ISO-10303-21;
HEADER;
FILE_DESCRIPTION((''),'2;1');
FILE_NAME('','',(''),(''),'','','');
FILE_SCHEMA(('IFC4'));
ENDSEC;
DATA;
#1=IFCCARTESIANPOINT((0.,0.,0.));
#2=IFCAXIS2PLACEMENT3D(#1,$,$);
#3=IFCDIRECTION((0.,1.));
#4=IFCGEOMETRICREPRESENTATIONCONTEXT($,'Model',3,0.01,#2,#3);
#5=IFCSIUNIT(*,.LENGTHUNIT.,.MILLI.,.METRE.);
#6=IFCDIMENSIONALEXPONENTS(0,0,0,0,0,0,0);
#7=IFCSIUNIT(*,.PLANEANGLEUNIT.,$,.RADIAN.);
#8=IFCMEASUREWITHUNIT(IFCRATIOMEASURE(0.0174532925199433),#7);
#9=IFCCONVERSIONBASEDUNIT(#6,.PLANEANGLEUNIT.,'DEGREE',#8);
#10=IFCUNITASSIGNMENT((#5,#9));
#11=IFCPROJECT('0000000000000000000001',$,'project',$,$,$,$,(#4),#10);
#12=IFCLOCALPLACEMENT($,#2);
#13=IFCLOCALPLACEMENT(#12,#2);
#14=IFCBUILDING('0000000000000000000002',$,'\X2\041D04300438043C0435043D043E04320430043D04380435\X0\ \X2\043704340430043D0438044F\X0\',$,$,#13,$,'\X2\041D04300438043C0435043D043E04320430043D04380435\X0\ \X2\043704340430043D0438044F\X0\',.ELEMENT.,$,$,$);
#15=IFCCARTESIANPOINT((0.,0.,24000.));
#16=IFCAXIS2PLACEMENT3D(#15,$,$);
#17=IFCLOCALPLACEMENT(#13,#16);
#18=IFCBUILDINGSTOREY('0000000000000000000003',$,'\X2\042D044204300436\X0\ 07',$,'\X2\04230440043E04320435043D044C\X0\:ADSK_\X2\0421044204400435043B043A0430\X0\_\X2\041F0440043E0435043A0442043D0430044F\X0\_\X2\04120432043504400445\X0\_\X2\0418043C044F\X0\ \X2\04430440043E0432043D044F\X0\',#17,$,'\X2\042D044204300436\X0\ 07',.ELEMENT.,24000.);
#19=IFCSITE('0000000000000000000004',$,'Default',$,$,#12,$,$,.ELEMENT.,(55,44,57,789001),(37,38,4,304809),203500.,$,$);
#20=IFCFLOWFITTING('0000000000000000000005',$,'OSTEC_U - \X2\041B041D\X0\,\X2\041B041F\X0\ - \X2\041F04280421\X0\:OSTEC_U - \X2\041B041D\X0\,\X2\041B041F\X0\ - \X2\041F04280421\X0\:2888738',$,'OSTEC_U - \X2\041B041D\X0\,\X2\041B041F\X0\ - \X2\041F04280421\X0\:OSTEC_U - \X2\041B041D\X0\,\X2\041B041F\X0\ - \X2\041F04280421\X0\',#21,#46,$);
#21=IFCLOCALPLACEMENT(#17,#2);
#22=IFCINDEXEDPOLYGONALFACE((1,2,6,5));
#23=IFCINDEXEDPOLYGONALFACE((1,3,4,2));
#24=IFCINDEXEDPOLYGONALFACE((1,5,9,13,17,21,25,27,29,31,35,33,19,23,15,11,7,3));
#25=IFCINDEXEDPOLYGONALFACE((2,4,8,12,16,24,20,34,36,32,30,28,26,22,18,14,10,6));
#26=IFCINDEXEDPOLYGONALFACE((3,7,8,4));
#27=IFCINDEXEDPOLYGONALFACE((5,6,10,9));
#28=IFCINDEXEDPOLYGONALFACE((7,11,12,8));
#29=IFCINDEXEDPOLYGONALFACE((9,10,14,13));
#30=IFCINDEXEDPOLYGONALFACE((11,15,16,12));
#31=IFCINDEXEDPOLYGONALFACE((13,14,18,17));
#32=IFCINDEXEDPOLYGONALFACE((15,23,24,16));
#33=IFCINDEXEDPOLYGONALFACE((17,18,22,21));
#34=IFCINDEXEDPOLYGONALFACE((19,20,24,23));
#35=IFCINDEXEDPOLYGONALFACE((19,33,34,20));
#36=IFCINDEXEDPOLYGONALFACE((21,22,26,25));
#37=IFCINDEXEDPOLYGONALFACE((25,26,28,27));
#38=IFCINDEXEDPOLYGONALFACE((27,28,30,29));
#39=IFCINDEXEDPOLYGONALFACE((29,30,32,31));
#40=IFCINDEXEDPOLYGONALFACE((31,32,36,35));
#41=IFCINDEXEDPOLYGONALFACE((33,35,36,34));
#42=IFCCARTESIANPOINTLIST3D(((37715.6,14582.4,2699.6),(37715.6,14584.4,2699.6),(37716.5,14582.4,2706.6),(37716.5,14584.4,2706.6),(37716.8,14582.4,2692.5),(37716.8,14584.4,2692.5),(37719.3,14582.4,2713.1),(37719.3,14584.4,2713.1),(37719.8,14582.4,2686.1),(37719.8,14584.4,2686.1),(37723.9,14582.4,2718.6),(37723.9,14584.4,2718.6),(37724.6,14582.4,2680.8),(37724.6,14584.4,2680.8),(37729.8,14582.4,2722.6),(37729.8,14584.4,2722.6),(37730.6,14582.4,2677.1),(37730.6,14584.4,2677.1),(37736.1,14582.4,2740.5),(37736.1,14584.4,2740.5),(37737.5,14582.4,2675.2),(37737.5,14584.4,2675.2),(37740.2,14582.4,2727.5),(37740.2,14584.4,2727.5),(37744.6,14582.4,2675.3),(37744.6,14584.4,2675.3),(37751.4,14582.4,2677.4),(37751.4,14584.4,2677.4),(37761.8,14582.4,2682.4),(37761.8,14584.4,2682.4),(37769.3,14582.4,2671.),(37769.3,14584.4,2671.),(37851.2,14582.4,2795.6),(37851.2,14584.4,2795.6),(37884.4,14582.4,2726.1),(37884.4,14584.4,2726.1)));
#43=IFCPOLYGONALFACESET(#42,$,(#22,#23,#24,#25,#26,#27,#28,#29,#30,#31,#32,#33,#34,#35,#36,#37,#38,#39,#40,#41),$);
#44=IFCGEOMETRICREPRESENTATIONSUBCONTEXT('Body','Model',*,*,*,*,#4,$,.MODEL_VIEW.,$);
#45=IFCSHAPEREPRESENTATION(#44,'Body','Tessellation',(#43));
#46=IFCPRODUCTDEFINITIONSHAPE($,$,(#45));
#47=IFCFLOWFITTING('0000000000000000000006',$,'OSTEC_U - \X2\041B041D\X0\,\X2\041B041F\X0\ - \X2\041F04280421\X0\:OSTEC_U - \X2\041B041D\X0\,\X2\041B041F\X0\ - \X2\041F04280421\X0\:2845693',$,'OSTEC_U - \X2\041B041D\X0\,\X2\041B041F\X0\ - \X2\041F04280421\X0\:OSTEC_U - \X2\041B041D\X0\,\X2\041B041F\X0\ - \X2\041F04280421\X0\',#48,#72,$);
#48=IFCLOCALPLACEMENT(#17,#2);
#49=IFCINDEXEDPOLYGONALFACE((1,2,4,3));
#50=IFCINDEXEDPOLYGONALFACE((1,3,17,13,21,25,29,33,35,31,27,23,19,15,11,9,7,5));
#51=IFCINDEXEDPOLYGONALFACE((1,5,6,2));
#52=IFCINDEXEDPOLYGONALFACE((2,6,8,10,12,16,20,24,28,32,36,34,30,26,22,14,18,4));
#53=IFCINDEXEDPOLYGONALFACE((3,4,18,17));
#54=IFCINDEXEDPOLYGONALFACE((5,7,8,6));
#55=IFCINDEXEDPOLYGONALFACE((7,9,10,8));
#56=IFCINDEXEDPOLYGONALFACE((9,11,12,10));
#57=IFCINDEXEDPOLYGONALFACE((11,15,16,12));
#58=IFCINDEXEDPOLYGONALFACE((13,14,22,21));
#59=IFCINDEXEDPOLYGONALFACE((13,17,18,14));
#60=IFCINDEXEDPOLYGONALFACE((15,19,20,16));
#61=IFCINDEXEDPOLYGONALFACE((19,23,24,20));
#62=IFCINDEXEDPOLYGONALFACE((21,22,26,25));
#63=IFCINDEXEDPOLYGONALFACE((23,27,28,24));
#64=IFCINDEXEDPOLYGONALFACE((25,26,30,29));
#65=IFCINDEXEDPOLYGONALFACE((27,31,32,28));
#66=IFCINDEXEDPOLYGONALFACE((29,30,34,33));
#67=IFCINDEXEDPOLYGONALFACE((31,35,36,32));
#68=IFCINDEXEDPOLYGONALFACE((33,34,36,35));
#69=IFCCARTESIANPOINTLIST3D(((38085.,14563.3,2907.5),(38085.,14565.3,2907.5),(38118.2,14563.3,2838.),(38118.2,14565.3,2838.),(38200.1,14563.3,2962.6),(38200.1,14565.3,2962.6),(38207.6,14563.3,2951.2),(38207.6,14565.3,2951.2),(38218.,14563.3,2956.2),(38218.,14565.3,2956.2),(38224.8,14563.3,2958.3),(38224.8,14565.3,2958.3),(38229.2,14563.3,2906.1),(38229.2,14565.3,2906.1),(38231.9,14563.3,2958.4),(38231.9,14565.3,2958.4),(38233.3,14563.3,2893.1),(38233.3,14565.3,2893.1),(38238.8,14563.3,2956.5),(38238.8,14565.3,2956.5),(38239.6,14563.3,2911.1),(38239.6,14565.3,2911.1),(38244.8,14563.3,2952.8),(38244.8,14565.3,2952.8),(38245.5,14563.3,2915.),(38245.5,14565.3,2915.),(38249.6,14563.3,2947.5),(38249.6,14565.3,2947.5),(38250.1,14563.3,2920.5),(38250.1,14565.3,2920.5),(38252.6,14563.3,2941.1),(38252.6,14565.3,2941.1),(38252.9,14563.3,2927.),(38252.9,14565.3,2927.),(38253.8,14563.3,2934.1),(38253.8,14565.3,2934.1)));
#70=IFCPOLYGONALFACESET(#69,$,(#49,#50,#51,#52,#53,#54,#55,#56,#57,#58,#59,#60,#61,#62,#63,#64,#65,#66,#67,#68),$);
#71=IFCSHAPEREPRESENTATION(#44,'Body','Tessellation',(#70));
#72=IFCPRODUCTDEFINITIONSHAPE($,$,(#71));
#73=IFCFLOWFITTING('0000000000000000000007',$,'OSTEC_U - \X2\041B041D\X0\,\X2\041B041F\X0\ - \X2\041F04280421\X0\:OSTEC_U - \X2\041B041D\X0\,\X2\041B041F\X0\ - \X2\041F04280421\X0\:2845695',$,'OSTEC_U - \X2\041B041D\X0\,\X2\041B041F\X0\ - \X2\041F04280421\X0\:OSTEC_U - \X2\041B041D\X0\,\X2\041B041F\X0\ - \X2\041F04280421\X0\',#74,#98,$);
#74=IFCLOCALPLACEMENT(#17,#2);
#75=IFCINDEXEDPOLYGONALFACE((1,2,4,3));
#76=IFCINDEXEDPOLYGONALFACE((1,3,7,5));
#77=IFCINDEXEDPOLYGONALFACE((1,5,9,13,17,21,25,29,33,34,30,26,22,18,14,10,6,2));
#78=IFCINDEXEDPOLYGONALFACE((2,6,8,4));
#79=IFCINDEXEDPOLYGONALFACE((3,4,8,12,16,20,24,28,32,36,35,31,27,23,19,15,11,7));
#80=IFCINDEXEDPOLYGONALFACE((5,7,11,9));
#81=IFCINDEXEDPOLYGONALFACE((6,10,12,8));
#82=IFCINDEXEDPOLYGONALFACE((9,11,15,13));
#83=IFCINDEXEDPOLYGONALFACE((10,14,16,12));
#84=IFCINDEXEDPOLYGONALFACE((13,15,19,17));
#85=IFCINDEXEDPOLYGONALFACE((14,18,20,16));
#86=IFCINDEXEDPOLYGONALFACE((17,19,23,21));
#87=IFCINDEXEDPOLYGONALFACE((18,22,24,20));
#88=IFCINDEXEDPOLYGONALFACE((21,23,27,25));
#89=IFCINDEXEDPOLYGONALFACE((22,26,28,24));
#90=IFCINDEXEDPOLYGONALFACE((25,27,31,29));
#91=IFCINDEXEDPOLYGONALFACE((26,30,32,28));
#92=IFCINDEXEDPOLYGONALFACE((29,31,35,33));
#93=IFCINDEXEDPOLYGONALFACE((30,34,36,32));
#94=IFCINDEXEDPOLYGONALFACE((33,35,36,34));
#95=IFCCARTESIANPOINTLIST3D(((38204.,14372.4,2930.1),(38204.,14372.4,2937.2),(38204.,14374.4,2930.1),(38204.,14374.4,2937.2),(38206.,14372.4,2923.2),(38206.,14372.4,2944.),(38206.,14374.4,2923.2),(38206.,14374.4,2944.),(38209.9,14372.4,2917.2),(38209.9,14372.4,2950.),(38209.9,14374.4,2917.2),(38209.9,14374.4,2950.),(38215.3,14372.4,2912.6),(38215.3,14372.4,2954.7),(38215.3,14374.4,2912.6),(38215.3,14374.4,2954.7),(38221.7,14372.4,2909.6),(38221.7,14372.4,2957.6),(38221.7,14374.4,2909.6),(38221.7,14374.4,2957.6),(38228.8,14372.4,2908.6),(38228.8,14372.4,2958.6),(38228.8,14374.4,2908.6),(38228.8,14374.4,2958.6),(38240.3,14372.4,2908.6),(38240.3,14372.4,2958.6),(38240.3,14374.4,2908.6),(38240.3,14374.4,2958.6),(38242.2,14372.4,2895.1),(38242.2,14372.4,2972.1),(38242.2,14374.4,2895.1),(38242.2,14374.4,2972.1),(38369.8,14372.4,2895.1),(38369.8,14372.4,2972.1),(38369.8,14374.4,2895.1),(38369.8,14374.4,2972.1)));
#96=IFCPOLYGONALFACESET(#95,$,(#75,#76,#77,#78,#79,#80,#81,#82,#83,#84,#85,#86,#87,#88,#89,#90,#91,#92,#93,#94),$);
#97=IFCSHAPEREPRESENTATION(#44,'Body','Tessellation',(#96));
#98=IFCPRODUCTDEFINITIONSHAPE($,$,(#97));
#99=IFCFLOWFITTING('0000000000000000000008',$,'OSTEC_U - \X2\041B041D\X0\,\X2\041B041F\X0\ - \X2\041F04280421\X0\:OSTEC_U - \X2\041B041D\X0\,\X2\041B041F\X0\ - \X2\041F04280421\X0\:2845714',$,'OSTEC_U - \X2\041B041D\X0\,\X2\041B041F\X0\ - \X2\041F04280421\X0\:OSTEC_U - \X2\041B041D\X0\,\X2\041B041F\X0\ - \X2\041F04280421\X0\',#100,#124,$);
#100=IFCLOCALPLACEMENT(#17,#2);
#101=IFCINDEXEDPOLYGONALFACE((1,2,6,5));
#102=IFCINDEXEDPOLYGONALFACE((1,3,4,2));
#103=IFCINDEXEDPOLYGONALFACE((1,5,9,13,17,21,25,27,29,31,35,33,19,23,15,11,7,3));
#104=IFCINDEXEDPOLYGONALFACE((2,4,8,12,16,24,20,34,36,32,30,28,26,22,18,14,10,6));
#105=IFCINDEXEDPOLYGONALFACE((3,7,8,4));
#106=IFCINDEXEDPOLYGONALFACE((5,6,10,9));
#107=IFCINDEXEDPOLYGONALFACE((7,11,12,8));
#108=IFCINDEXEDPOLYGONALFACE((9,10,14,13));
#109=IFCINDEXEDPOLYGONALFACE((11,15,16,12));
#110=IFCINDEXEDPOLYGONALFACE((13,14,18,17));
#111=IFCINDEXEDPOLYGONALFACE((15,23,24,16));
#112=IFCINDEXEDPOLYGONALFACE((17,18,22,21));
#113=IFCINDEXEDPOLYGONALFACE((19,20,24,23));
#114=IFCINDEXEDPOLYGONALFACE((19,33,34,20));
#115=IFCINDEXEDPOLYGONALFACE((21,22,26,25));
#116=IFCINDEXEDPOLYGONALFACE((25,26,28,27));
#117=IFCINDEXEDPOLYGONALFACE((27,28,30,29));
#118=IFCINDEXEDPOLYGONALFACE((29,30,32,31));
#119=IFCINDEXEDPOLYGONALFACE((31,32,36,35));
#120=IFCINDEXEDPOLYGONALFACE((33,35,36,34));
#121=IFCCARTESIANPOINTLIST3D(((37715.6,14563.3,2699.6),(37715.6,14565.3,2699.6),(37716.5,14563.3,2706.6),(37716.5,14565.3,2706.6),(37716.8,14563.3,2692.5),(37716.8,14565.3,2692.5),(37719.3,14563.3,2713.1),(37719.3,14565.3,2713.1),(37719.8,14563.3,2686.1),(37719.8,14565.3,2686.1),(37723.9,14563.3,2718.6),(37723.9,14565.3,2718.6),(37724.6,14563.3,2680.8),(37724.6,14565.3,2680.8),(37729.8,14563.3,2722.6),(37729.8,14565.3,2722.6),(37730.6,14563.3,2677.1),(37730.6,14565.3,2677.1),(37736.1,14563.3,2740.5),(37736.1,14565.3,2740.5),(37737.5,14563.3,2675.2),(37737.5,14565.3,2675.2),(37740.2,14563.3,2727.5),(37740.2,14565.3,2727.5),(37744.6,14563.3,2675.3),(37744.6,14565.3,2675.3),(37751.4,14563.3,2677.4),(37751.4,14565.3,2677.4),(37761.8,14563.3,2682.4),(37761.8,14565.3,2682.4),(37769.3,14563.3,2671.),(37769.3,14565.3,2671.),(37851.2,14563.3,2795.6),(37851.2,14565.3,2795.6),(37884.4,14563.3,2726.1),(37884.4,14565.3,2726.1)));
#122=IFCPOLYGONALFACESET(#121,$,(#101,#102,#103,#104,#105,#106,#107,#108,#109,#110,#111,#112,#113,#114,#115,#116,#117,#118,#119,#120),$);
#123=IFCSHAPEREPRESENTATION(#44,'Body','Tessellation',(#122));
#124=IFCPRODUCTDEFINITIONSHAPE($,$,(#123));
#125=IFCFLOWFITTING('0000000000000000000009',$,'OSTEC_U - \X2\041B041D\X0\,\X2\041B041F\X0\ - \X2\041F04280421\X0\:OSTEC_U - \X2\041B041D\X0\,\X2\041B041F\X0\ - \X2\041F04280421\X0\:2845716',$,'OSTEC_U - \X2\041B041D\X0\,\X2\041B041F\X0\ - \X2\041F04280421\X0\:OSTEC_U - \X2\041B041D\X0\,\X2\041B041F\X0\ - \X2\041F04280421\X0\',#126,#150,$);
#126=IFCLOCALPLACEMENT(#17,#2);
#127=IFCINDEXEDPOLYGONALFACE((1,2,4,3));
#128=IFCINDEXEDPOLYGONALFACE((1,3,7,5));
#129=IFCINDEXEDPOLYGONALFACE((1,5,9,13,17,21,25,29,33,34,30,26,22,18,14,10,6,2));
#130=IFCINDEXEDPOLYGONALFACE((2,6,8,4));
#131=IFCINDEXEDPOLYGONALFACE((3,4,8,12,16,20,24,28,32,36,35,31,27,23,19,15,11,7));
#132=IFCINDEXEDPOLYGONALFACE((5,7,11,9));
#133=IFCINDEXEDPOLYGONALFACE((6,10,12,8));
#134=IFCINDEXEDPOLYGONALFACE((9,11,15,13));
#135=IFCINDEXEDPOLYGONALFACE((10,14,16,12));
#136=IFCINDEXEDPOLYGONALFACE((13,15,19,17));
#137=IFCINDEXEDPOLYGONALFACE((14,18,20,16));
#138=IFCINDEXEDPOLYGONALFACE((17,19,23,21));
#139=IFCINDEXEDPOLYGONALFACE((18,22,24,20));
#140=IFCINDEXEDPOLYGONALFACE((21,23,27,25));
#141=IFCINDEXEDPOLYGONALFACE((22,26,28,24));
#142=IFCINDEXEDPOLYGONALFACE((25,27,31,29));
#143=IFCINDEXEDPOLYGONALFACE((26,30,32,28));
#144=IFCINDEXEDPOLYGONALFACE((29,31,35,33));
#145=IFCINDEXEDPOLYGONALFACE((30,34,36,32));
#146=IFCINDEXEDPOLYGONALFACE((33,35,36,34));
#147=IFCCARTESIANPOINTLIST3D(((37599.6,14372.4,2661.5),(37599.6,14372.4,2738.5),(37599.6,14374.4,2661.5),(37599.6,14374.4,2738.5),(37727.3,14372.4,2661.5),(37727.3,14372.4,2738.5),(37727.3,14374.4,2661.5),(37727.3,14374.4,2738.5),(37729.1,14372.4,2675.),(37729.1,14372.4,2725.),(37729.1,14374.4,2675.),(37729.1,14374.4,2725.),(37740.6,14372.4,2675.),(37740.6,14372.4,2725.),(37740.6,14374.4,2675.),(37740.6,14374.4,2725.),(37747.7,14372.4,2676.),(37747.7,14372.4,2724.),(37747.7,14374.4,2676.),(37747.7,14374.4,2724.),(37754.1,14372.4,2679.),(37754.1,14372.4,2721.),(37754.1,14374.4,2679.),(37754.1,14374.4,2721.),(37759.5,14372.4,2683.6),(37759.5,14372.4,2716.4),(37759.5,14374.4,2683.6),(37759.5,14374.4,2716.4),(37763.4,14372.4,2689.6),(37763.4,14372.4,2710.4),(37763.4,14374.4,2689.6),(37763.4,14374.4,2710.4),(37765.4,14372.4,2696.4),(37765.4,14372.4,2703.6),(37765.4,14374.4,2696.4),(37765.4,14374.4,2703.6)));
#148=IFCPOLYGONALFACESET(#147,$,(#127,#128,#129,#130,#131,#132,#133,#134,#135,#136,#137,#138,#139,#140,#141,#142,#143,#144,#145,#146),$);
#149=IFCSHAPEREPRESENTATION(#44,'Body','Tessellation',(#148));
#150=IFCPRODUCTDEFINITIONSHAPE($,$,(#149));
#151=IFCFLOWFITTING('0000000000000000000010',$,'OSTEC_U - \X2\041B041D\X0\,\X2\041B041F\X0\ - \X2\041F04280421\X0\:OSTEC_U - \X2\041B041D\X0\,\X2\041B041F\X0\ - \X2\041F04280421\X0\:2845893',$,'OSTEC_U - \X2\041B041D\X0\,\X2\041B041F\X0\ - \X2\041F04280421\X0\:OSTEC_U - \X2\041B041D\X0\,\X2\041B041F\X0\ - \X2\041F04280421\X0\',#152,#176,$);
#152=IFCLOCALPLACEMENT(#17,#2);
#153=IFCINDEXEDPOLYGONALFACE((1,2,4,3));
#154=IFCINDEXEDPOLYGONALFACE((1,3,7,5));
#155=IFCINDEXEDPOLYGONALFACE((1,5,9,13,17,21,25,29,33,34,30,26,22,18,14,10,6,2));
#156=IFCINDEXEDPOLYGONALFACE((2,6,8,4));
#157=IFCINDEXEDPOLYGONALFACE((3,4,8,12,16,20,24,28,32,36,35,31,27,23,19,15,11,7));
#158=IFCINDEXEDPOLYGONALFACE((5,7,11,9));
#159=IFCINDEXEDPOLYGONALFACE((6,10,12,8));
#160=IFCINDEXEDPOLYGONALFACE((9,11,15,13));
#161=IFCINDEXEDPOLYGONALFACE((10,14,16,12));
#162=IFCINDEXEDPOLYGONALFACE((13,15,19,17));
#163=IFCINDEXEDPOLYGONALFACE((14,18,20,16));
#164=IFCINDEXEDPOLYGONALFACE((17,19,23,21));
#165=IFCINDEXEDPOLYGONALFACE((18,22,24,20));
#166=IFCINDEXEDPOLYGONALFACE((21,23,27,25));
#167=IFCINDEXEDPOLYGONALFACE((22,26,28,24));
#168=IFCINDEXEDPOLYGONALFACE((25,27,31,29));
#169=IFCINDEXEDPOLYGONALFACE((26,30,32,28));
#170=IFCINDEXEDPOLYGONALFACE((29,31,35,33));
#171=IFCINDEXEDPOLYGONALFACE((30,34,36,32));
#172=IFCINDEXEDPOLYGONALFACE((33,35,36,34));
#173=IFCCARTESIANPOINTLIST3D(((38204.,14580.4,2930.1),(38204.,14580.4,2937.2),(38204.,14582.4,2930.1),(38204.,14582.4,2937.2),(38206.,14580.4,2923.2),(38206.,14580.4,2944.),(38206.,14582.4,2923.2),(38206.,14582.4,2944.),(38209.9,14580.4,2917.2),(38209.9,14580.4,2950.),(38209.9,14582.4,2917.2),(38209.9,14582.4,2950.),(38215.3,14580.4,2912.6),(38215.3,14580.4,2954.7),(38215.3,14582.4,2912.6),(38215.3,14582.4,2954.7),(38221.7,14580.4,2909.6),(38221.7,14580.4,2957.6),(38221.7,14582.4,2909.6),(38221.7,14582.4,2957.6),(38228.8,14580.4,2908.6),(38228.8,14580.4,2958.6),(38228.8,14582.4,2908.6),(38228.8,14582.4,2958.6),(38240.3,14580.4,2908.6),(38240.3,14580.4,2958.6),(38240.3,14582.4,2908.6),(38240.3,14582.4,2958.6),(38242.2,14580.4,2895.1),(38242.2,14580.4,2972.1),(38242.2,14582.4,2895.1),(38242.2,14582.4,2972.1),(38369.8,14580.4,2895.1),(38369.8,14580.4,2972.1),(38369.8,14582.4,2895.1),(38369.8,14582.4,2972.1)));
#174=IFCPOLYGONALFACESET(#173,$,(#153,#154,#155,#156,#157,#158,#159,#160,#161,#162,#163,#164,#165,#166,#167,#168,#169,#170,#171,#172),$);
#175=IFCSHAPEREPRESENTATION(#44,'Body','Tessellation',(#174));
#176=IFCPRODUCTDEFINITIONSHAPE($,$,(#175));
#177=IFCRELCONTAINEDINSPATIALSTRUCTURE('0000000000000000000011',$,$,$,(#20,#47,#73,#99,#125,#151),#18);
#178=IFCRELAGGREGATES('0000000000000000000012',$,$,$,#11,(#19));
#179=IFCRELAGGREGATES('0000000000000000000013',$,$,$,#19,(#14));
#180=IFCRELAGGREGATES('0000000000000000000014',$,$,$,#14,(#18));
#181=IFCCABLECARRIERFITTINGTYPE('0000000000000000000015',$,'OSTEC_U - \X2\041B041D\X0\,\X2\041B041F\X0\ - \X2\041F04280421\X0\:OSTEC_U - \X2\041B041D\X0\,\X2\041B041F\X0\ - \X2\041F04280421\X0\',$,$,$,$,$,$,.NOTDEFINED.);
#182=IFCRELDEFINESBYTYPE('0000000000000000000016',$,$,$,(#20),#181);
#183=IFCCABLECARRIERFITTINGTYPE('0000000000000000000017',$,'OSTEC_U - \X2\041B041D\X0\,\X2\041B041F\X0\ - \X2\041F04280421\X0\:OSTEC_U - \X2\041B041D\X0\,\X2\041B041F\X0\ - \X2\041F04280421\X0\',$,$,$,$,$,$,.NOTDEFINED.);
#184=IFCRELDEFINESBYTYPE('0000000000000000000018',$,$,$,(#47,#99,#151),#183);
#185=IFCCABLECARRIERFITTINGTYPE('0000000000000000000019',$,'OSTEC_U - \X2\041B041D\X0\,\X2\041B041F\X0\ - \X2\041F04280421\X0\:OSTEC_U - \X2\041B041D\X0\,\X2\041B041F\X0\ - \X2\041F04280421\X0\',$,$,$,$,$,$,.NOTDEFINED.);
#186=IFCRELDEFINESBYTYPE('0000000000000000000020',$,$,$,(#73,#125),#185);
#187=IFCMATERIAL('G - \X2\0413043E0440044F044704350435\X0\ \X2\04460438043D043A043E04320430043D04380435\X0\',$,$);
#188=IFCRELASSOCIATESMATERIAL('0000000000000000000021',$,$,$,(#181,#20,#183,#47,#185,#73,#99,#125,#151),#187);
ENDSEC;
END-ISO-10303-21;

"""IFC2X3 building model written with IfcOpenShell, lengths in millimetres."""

from ifc_helpers import new_model, entity, si_unit, converted_unit, direction, frame, frame_2d, origin, place, context, subcontext, project, spatial, polyline, circle_curve, parameter, trimmed, segment, composite_curve, outline, extrude, source, transform, mapped, material, type_object, type_shapes, element, save


model = new_model("IFC2X3")

# Units and contexts
model_context = context("Model", 3, precision=0.01, world=origin(), true_north=direction((0.0, 1.0)))
body_context = subcontext(model_context, "Body", "Model", "MODEL_VIEW")
ifc_project = project(units=[si_unit("LENGTHUNIT", "METRE", prefix="MILLI"), converted_unit("PLANEANGLEUNIT", "DEGREE", entity("IfcRatioMeasure", 0.0174532925199433), si_unit("PLANEANGLEUNIT", "RADIAN"), dimensions=[0, 0, 0, 0, 0, 0, 0])], contexts=[model_context])

# Site, building, storey
site_placement = place(None, origin())
site = spatial("IfcSite", under=ifc_project, at=site_placement, Name="Default", CompositionType="ELEMENT", RefLatitude=(55, 44, 57, 789001), RefLongitude=(37, 38, 4, 304809), RefElevation=203500.0)
building_placement = place(site_placement, origin())
building = spatial("IfcBuilding", under=site, at=building_placement, Name="Наименование здания", LongName="Наименование здания", CompositionType="ELEMENT")
storey_placement = place(building_placement, frame((0.0, 0.0, 24000.0)))
storey = spatial("IfcBuildingStorey", under=building, at=storey_placement, Name="Этаж 07", ObjectType="Уровень:ADSK_Стрелка_Проектная_Вверх_Имя уровня", LongName="Этаж 07", CompositionType="ELEMENT", Elevation=24000.0)

# Flow fittings
ifc_material_1 = material(Name="G - Горячее цинкование")
shared_shape_1 = source(origin(), body_context, "Body", "SweptSolid", [
    extrude(outline(composite_curve([segment(trimmed(circle_curve(frame_2d((-41.5, 0.0), x_axis=(1.0, 0.0)), 25.0), [parameter(90.0)], [parameter(270.0)], True, "PARAMETER"), True, "CONTINUOUS"), segment(polyline([(-41.5, -25.0), (-30.0, -25.0)]), True, "CONTINUOUS"), segment(polyline([(-30.0, -25.0), (-28.1, -38.5)]), True, "CONTINUOUS"), segment(polyline([(-28.1, -38.5), (99.5, -38.5)]), True, "CONTINUOUS"), segment(polyline([(99.5, -38.5), (99.5, 38.5)]), True, "CONTINUOUS"), segment(polyline([(99.5, 38.5), (-28.1, 38.5)]), True, "CONTINUOUS"), segment(polyline([(-28.1, 38.5), (-30.0, 25.0)]), True, "CONTINUOUS"), segment(polyline([(-30.0, 25.0), (-41.5, 25.0)]), True, "CONTINUOUS")], self_intersect=False)), frame((41.5, 0.0, 0.0), z_axis=(0.0, 0.0, -1.0), x_axis=(1.0, 0.0, 0.0)), (0.0, 0.0, -1.0), 2.0),
])
cable_carrier_fitting_type_1 = type_object("IfcCableCarrierFittingType", Name="OSTEC_U - ЛН,ЛП - ПШС:OSTEC_U - ЛН,ЛП - ПШС", PredefinedType="NOTDEFINED", material=ifc_material_1)
type_shapes(cable_carrier_fitting_type_1, [shared_shape_1])
flow_fitting_1_placement = place(storey_placement, frame((37740.6, 14584.4, 2700.0), z_axis=(0.0, -1.0, 0.0), x_axis=(0.90203, 0.0, 0.431673)))
element("IfcFlowFitting", 1, at=flow_fitting_1_placement, inside=storey, type_object=cable_carrier_fitting_type_1, material=ifc_material_1, Name="OSTEC_U - ЛН,ЛП - ПШС:OSTEC_U - ЛН,ЛП - ПШС:2888738", ObjectType="OSTEC_U - ЛН,ЛП - ПШС:OSTEC_U - ЛН,ЛП - ПШС", context=body_context, shape_type="MappedRepresentation", body=[
    mapped(shared_shape_1, transform((0.0, 0.0, 0.0), scale=1.0)),
])
cable_carrier_fitting_type_2 = type_object("IfcCableCarrierFittingType", Name="OSTEC_U - ЛН,ЛП - ПШС:OSTEC_U - ЛН,ЛП - ПШС", PredefinedType="NOTDEFINED", material=ifc_material_1)
shared_shape_2 = source(origin(), body_context, "Body", "SweptSolid", [
    extrude(outline(composite_curve([segment(trimmed(circle_curve(frame_2d((-41.5, 0.0), x_axis=(1.0, 0.0)), 25.0), [parameter(90.0)], [parameter(270.0)], True, "PARAMETER"), True, "CONTINUOUS"), segment(polyline([(-41.5, -25.0), (-30.0, -25.0)]), True, "CONTINUOUS"), segment(polyline([(-30.0, -25.0), (-28.1, -38.5)]), True, "CONTINUOUS"), segment(polyline([(-28.1, -38.5), (99.5, -38.5)]), True, "CONTINUOUS"), segment(polyline([(99.5, -38.5), (99.5, 38.5)]), True, "CONTINUOUS"), segment(polyline([(99.5, 38.5), (-28.1, 38.5)]), True, "CONTINUOUS"), segment(polyline([(-28.1, 38.5), (-30.0, 25.0)]), True, "CONTINUOUS"), segment(polyline([(-30.0, 25.0), (-41.5, 25.0)]), True, "CONTINUOUS")], self_intersect=False)), frame((41.5, 0.0, 0.0)), (0.0, 0.0, 1.0), 2.0),
])
type_shapes(cable_carrier_fitting_type_2, [shared_shape_2])
flow_fitting_2_placement = place(storey_placement, frame((38228.8, 14563.3, 2933.6), z_axis=(0.0, 1.0, 0.0), x_axis=(-0.90203, 0.0, -0.431673)))
element("IfcFlowFitting", 2, at=flow_fitting_2_placement, inside=storey, type_object=cable_carrier_fitting_type_2, material=ifc_material_1, Name="OSTEC_U - ЛН,ЛП - ПШС:OSTEC_U - ЛН,ЛП - ПШС:2845693", ObjectType="OSTEC_U - ЛН,ЛП - ПШС:OSTEC_U - ЛН,ЛП - ПШС", context=body_context, shape_type="MappedRepresentation", body=[
    mapped(shared_shape_2, transform((0.0, 0.0, 0.0), scale=1.0)),
])
cable_carrier_fitting_type_3 = type_object("IfcCableCarrierFittingType", Name="OSTEC_U - ЛН,ЛП - ПШС:OSTEC_U - ЛН,ЛП - ПШС", PredefinedType="NOTDEFINED", material=ifc_material_1)
type_shapes(cable_carrier_fitting_type_3, [shared_shape_2])
flow_fitting_3_placement = place(storey_placement, frame((38228.8, 14374.4, 2933.6), z_axis=(0.0, -1.0, 0.0), x_axis=(1.0, 0.0, 0.0)))
element("IfcFlowFitting", 3, at=flow_fitting_3_placement, inside=storey, type_object=cable_carrier_fitting_type_3, material=ifc_material_1, Name="OSTEC_U - ЛН,ЛП - ПШС:OSTEC_U - ЛН,ЛП - ПШС:2845695", ObjectType="OSTEC_U - ЛН,ЛП - ПШС:OSTEC_U - ЛН,ЛП - ПШС", context=body_context, shape_type="MappedRepresentation", body=[
    mapped(shared_shape_2, transform((0.0, 0.0, 0.0), scale=1.0)),
])
flow_fitting_4_placement = place(storey_placement, frame((37740.6, 14563.3, 2700.0), z_axis=(0.0, 1.0, 0.0), x_axis=(0.90203, 0.0, 0.431673)))
element("IfcFlowFitting", 4, at=flow_fitting_4_placement, inside=storey, type_object=cable_carrier_fitting_type_2, material=ifc_material_1, Name="OSTEC_U - ЛН,ЛП - ПШС:OSTEC_U - ЛН,ЛП - ПШС:2845714", ObjectType="OSTEC_U - ЛН,ЛП - ПШС:OSTEC_U - ЛН,ЛП - ПШС", context=body_context, shape_type="MappedRepresentation", body=[
    mapped(shared_shape_2, transform((0.0, 0.0, 0.0), scale=1.0)),
])
flow_fitting_5_placement = place(storey_placement, frame((37740.6, 14374.4, 2700.0), z_axis=(0.0, -1.0, 0.0), x_axis=(-1.0, 0.0, 0.0)))
element("IfcFlowFitting", 5, at=flow_fitting_5_placement, inside=storey, type_object=cable_carrier_fitting_type_3, material=ifc_material_1, Name="OSTEC_U - ЛН,ЛП - ПШС:OSTEC_U - ЛН,ЛП - ПШС:2845716", ObjectType="OSTEC_U - ЛН,ЛП - ПШС:OSTEC_U - ЛН,ЛП - ПШС", context=body_context, shape_type="MappedRepresentation", body=[
    mapped(shared_shape_2, transform((0.0, 0.0, 0.0), scale=1.0)),
])
flow_fitting_6_placement = place(storey_placement, frame((38228.8, 14582.4, 2933.6), z_axis=(0.0, -1.0, 0.0), x_axis=(1.0, 0.0, 0.0)))
element("IfcFlowFitting", 6, at=flow_fitting_6_placement, inside=storey, type_object=cable_carrier_fitting_type_2, material=ifc_material_1, Name="OSTEC_U - ЛН,ЛП - ПШС:OSTEC_U - ЛН,ЛП - ПШС:2845893", ObjectType="OSTEC_U - ЛН,ЛП - ПШС:OSTEC_U - ЛН,ЛП - ПШС", context=body_context, shape_type="MappedRepresentation", body=[
    mapped(shared_shape_2, transform((0.0, 0.0, 0.0), scale=1.0)),
])

save(model, "model.ifc")
